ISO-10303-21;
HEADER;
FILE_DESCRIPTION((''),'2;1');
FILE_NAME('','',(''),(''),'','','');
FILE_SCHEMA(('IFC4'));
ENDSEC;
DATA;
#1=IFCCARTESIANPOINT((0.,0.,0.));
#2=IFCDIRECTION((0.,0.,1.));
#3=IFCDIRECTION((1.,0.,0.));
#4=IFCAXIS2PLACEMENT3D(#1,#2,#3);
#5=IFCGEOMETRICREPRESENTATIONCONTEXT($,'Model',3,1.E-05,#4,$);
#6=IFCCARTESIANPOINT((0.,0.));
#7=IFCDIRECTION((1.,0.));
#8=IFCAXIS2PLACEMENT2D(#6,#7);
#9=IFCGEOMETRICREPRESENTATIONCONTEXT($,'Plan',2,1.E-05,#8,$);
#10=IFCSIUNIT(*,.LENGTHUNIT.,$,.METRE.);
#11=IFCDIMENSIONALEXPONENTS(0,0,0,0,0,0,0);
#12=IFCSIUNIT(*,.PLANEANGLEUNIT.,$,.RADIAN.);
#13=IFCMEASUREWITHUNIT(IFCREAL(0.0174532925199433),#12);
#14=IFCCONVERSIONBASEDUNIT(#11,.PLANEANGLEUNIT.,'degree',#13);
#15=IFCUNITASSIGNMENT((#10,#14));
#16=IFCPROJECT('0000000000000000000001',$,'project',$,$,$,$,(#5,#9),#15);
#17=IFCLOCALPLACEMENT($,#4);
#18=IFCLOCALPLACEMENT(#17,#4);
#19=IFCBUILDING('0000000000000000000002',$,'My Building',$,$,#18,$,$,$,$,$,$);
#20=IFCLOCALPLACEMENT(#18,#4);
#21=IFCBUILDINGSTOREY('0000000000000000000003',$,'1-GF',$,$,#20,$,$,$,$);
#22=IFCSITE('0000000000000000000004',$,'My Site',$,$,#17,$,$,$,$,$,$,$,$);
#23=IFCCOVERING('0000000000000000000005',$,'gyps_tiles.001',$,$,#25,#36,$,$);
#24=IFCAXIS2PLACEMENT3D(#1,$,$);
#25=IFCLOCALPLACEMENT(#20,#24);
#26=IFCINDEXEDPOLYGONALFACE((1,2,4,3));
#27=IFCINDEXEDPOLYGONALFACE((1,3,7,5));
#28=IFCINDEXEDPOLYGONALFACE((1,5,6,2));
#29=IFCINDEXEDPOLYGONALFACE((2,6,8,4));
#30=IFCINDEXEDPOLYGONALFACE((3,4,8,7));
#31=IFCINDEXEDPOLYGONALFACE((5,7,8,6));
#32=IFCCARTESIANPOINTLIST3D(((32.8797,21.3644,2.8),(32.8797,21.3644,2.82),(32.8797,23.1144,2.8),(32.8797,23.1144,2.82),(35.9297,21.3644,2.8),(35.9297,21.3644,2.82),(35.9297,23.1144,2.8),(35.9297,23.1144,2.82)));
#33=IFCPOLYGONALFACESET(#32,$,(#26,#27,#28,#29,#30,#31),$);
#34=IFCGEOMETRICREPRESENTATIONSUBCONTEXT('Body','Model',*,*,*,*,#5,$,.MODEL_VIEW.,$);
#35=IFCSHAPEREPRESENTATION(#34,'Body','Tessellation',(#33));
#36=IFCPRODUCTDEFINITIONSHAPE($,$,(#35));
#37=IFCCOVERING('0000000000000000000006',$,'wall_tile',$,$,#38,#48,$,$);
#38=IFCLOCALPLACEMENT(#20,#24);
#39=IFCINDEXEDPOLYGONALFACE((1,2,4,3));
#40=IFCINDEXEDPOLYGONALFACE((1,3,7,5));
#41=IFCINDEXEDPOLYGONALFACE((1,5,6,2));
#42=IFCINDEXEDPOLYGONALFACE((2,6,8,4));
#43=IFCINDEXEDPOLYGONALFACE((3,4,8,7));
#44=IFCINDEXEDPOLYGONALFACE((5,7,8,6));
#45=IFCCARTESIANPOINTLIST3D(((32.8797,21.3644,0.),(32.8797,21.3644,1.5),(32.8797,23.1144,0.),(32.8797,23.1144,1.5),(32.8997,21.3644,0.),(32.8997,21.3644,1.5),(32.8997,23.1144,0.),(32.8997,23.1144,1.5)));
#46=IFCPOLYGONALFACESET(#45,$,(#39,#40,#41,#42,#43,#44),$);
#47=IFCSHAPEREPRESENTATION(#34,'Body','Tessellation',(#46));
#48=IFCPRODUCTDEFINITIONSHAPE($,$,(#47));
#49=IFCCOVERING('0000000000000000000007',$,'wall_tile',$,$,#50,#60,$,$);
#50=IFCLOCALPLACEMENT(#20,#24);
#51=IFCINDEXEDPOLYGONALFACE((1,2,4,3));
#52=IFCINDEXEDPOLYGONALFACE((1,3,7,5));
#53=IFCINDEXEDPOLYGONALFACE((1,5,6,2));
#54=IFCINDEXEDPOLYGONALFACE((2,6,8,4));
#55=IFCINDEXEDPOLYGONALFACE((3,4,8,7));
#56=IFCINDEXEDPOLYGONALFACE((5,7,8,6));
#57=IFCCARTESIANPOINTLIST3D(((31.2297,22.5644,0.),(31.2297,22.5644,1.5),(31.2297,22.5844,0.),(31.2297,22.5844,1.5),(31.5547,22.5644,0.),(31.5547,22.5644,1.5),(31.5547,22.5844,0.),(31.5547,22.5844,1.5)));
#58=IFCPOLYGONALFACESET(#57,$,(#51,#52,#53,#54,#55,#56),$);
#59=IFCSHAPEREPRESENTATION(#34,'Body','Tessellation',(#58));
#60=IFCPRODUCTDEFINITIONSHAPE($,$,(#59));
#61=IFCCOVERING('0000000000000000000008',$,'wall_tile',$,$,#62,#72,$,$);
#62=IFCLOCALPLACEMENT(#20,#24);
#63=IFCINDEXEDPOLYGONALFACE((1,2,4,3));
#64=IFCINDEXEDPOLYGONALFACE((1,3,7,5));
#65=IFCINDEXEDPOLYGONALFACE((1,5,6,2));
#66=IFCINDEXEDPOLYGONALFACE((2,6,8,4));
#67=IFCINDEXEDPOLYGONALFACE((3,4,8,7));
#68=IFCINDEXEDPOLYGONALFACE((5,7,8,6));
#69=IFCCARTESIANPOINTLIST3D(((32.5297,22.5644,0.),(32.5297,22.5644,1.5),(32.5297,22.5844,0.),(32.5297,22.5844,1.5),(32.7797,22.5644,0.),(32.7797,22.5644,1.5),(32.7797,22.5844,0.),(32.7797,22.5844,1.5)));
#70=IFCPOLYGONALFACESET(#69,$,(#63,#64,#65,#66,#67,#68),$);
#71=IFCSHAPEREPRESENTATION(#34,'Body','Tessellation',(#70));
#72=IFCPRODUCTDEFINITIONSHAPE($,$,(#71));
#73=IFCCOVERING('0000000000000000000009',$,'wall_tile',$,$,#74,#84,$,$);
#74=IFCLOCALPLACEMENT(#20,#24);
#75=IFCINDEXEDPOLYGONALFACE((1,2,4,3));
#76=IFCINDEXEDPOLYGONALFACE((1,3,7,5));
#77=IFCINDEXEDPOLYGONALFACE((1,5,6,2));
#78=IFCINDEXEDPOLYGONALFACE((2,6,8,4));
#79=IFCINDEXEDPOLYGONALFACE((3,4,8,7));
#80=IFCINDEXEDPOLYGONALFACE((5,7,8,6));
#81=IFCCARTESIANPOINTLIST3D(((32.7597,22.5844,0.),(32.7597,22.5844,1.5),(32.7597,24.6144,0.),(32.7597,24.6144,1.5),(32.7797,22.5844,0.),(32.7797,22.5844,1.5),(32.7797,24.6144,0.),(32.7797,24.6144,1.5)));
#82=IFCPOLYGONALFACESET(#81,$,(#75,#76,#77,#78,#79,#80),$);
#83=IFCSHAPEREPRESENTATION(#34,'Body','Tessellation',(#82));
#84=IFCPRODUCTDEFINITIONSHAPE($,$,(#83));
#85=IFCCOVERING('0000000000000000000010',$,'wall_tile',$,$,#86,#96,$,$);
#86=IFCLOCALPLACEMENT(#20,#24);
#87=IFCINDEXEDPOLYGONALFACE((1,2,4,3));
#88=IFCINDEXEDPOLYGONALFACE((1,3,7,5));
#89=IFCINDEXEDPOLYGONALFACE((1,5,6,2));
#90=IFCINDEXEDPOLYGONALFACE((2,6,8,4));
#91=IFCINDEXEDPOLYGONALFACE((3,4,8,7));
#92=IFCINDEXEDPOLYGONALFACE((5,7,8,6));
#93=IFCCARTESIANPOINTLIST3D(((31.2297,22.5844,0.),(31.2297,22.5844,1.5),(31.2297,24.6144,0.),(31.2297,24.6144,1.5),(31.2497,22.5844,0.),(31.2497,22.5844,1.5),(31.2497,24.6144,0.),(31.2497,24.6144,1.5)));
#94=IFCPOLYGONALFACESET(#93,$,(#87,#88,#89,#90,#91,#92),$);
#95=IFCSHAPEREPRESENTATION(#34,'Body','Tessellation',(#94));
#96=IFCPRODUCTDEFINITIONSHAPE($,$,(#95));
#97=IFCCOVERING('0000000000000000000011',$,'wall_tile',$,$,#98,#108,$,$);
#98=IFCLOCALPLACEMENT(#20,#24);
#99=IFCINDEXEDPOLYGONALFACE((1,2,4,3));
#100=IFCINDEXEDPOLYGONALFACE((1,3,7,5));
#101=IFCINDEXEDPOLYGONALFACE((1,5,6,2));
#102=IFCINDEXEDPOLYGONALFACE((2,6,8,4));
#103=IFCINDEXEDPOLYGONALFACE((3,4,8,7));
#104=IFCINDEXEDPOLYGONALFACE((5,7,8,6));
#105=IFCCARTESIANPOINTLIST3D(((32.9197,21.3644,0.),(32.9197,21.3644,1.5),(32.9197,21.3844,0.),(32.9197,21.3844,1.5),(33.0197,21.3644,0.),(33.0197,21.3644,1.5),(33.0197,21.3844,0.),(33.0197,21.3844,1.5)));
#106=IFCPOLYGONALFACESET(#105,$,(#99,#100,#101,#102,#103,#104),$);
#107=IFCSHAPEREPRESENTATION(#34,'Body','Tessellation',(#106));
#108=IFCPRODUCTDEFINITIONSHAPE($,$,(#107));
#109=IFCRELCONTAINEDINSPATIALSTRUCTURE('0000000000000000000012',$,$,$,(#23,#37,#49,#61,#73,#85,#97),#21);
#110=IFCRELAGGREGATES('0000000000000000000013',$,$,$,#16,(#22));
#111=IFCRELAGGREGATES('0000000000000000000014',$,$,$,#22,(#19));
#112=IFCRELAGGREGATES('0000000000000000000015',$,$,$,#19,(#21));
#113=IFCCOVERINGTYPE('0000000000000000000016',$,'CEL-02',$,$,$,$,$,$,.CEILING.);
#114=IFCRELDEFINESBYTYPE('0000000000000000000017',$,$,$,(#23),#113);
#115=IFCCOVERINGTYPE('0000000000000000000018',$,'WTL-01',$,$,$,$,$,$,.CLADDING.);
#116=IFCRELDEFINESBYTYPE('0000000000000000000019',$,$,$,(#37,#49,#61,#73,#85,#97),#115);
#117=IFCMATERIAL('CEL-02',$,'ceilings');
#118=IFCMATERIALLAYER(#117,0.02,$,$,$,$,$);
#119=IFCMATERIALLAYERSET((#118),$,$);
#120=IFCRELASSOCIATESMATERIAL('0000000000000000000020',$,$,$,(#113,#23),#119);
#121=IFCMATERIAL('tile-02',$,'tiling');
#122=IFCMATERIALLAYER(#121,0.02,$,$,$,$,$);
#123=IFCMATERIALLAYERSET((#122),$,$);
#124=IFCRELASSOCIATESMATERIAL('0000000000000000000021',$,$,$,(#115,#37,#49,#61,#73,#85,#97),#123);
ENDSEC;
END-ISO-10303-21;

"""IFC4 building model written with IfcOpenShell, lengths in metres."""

from ifc_helpers import new_model, entity, si_unit, converted_unit, frame, origin_with_axes, origin_2d_with_axis, place, context, subcontext, project, spatial, line, indexed_curve, outline, extrude, material, layer, layer_set, layer_usage, type_object, element, save


model = new_model("IFC4")

# Units and contexts
model_context = context("Model", 3, precision=1e-05, world=origin_with_axes())
plan_context = context("Plan", 2, precision=1e-05, world=origin_2d_with_axis())
body_context_1 = subcontext(model_context, "Body", "Model", "MODEL_VIEW")
ifc_project = project(units=[si_unit("LENGTHUNIT", "METRE"), converted_unit("PLANEANGLEUNIT", "degree", entity("IfcReal", 0.0174532925199433), si_unit("PLANEANGLEUNIT", "RADIAN"), dimensions=[0, 0, 0, 0, 0, 0, 0])], contexts=[model_context, plan_context])

# Site, building, storey
site_placement = place(None, origin_with_axes())
site = spatial("IfcSite", under=ifc_project, at=site_placement, Name="My Site")
building_placement = place(site_placement, origin_with_axes())
building = spatial("IfcBuilding", under=site, at=building_placement, Name="My Building")
storey_placement = place(building_placement, origin_with_axes())
storey = spatial("IfcBuildingStorey", under=building, at=storey_placement, Name="1-GF")

# Coverings
ifc_material_1 = material(Name="CEL-02", Category="ceilings")
ifc_layer_1 = layer(ifc_material_1, 0.02)
ifc_layer_set_1 = layer_set([ifc_layer_1])
ifc_layer_usage_1 = layer_usage(ifc_layer_set_1, "AXIS3", "POSITIVE", 0.0)
covering_type_1 = type_object("IfcCoveringType", Name="CEL-02", PredefinedType="CEILING", material=ifc_layer_set_1)
covering_1_placement = place(storey_placement, frame((32.8797, 21.3644, 2.8), z_axis=(0.0, 0.0, 1.0), x_axis=(1.0, 0.0, 0.0)))
element("IfcCovering", 1, at=covering_1_placement, inside=storey, type_object=covering_type_1, material=ifc_layer_usage_1, Name="gyps_tiles.001", context=body_context_1, shape_type="SweptSolid", body=[
    extrude(outline(indexed_curve([(0.0, 1.75), (0.0, 0.0), (3.05, 0.0), (3.05, 1.75)], segments=[line(3, 2), line(2, 1), line(1, 4), line(4, 3)], self_intersect=False)), None, (0.0, 0.0, 1.0), 0.02),
])
ifc_material_2 = material(Name="tile-02", Category="tiling")
ifc_layer_2 = layer(ifc_material_2, 0.02)
ifc_layer_set_2 = layer_set([ifc_layer_2])
ifc_layer_usage_2 = layer_usage(ifc_layer_set_2, "AXIS2", "POSITIVE", 0.0)
covering_type_2 = type_object("IfcCoveringType", Name="WTL-01", PredefinedType="CLADDING", material=ifc_layer_set_2)
covering_2_placement = place(storey_placement, frame((32.8997, 21.3644, 0.0), z_axis=(0.0, 0.0, 1.0), x_axis=(0.000001, 1.0, 0.0)))
element("IfcCovering", 2, at=covering_2_placement, inside=storey, type_object=covering_type_2, material=ifc_layer_usage_2, Name="wall_tile", context=body_context_1, shape_type="SweptSolid", body=[
    extrude(outline(indexed_curve([(0.0, 0.0), (0.0, 0.02), (1.75, 0.02), (1.75, 0.0), (0.0, 0.0)], self_intersect=False)), origin_with_axes(), (0.0, 0.0, 1.0), 1.5),
])
ifc_layer_usage_3 = layer_usage(ifc_layer_set_2, "AXIS2", "POSITIVE", 0.0)
covering_3_placement = place(storey_placement, frame((31.5547, 22.5844, 0.0), z_axis=(0.0, 0.0, 1.0), x_axis=(-1.0, 0.000001, 0.0)))
element("IfcCovering", 3, at=covering_3_placement, inside=storey, type_object=covering_type_2, material=ifc_layer_usage_3, Name="wall_tile", context=body_context_1, shape_type="SweptSolid", body=[
    extrude(outline(indexed_curve([(0.0, 0.0), (0.0, 0.02), (0.325, 0.02), (0.325, 0.0), (0.0, 0.0)], self_intersect=False)), origin_with_axes(), (0.0, 0.0, 1.0), 1.5),
])
ifc_layer_usage_4 = layer_usage(ifc_layer_set_2, "AXIS2", "POSITIVE", 0.0)
covering_4_placement = place(storey_placement, frame((32.7797, 22.5844, 0.0), z_axis=(0.0, 0.0, 1.0), x_axis=(-1.0, 0.000001, 0.0)))
element("IfcCovering", 4, at=covering_4_placement, inside=storey, type_object=covering_type_2, material=ifc_layer_usage_4, Name="wall_tile", context=body_context_1, shape_type="SweptSolid", body=[
    extrude(outline(indexed_curve([(0.0, 0.0), (0.0, 0.02), (0.25, 0.02), (0.25, 0.0), (0.0, 0.0)], self_intersect=False)), origin_with_axes(), (0.0, 0.0, 1.0), 1.5),
])
ifc_layer_usage_5 = layer_usage(ifc_layer_set_2, "AXIS2", "POSITIVE", 0.0)
covering_5_placement = place(storey_placement, frame((32.7797, 22.5844, 0.0), z_axis=(0.0, 0.0, 1.0), x_axis=(0.000001, 1.0, 0.0)))
element("IfcCovering", 5, at=covering_5_placement, inside=storey, type_object=covering_type_2, material=ifc_layer_usage_5, Name="wall_tile", context=body_context_1, shape_type="SweptSolid", body=[
    extrude(outline(indexed_curve([(0.0, 0.0), (0.0, 0.02), (2.03, 0.02), (2.03, 0.0), (0.0, 0.0)], self_intersect=False)), origin_with_axes(), (0.0, 0.0, 1.0), 1.5),
])
ifc_layer_usage_6 = layer_usage(ifc_layer_set_2, "AXIS2", "POSITIVE", 0.0)
covering_6_placement = place(storey_placement, frame((31.2497, 22.5844, 0.0), z_axis=(0.0, 0.0, 1.0), x_axis=(0.000001, 1.0, 0.0)))
element("IfcCovering", 6, at=covering_6_placement, inside=storey, type_object=covering_type_2, material=ifc_layer_usage_6, Name="wall_tile", context=body_context_1, shape_type="SweptSolid", body=[
    extrude(outline(indexed_curve([(0.0, 0.0), (0.0, 0.02), (2.03, 0.02), (2.03, 0.0), (0.0, 0.0)], self_intersect=False)), origin_with_axes(), (0.0, 0.0, 1.0), 1.5),
])
ifc_layer_usage_7 = layer_usage(ifc_layer_set_2, "AXIS2", "POSITIVE", 0.0)
covering_7_placement = place(storey_placement, frame((33.0197, 21.3844, 0.0), z_axis=(0.0, 0.0, 1.0), x_axis=(-1.0, 0.000001, 0.0)))
element("IfcCovering", 7, at=covering_7_placement, inside=storey, type_object=covering_type_2, material=ifc_layer_usage_7, Name="wall_tile", context=body_context_1, shape_type="SweptSolid", body=[
    extrude(outline(indexed_curve([(0.0, 0.0), (0.0, 0.02), (0.1, 0.02), (0.1, 0.0), (0.0, 0.0)], self_intersect=False)), origin_with_axes(), (0.0, 0.0, 1.0), 1.5),
])

save(model, "model.ifc")
